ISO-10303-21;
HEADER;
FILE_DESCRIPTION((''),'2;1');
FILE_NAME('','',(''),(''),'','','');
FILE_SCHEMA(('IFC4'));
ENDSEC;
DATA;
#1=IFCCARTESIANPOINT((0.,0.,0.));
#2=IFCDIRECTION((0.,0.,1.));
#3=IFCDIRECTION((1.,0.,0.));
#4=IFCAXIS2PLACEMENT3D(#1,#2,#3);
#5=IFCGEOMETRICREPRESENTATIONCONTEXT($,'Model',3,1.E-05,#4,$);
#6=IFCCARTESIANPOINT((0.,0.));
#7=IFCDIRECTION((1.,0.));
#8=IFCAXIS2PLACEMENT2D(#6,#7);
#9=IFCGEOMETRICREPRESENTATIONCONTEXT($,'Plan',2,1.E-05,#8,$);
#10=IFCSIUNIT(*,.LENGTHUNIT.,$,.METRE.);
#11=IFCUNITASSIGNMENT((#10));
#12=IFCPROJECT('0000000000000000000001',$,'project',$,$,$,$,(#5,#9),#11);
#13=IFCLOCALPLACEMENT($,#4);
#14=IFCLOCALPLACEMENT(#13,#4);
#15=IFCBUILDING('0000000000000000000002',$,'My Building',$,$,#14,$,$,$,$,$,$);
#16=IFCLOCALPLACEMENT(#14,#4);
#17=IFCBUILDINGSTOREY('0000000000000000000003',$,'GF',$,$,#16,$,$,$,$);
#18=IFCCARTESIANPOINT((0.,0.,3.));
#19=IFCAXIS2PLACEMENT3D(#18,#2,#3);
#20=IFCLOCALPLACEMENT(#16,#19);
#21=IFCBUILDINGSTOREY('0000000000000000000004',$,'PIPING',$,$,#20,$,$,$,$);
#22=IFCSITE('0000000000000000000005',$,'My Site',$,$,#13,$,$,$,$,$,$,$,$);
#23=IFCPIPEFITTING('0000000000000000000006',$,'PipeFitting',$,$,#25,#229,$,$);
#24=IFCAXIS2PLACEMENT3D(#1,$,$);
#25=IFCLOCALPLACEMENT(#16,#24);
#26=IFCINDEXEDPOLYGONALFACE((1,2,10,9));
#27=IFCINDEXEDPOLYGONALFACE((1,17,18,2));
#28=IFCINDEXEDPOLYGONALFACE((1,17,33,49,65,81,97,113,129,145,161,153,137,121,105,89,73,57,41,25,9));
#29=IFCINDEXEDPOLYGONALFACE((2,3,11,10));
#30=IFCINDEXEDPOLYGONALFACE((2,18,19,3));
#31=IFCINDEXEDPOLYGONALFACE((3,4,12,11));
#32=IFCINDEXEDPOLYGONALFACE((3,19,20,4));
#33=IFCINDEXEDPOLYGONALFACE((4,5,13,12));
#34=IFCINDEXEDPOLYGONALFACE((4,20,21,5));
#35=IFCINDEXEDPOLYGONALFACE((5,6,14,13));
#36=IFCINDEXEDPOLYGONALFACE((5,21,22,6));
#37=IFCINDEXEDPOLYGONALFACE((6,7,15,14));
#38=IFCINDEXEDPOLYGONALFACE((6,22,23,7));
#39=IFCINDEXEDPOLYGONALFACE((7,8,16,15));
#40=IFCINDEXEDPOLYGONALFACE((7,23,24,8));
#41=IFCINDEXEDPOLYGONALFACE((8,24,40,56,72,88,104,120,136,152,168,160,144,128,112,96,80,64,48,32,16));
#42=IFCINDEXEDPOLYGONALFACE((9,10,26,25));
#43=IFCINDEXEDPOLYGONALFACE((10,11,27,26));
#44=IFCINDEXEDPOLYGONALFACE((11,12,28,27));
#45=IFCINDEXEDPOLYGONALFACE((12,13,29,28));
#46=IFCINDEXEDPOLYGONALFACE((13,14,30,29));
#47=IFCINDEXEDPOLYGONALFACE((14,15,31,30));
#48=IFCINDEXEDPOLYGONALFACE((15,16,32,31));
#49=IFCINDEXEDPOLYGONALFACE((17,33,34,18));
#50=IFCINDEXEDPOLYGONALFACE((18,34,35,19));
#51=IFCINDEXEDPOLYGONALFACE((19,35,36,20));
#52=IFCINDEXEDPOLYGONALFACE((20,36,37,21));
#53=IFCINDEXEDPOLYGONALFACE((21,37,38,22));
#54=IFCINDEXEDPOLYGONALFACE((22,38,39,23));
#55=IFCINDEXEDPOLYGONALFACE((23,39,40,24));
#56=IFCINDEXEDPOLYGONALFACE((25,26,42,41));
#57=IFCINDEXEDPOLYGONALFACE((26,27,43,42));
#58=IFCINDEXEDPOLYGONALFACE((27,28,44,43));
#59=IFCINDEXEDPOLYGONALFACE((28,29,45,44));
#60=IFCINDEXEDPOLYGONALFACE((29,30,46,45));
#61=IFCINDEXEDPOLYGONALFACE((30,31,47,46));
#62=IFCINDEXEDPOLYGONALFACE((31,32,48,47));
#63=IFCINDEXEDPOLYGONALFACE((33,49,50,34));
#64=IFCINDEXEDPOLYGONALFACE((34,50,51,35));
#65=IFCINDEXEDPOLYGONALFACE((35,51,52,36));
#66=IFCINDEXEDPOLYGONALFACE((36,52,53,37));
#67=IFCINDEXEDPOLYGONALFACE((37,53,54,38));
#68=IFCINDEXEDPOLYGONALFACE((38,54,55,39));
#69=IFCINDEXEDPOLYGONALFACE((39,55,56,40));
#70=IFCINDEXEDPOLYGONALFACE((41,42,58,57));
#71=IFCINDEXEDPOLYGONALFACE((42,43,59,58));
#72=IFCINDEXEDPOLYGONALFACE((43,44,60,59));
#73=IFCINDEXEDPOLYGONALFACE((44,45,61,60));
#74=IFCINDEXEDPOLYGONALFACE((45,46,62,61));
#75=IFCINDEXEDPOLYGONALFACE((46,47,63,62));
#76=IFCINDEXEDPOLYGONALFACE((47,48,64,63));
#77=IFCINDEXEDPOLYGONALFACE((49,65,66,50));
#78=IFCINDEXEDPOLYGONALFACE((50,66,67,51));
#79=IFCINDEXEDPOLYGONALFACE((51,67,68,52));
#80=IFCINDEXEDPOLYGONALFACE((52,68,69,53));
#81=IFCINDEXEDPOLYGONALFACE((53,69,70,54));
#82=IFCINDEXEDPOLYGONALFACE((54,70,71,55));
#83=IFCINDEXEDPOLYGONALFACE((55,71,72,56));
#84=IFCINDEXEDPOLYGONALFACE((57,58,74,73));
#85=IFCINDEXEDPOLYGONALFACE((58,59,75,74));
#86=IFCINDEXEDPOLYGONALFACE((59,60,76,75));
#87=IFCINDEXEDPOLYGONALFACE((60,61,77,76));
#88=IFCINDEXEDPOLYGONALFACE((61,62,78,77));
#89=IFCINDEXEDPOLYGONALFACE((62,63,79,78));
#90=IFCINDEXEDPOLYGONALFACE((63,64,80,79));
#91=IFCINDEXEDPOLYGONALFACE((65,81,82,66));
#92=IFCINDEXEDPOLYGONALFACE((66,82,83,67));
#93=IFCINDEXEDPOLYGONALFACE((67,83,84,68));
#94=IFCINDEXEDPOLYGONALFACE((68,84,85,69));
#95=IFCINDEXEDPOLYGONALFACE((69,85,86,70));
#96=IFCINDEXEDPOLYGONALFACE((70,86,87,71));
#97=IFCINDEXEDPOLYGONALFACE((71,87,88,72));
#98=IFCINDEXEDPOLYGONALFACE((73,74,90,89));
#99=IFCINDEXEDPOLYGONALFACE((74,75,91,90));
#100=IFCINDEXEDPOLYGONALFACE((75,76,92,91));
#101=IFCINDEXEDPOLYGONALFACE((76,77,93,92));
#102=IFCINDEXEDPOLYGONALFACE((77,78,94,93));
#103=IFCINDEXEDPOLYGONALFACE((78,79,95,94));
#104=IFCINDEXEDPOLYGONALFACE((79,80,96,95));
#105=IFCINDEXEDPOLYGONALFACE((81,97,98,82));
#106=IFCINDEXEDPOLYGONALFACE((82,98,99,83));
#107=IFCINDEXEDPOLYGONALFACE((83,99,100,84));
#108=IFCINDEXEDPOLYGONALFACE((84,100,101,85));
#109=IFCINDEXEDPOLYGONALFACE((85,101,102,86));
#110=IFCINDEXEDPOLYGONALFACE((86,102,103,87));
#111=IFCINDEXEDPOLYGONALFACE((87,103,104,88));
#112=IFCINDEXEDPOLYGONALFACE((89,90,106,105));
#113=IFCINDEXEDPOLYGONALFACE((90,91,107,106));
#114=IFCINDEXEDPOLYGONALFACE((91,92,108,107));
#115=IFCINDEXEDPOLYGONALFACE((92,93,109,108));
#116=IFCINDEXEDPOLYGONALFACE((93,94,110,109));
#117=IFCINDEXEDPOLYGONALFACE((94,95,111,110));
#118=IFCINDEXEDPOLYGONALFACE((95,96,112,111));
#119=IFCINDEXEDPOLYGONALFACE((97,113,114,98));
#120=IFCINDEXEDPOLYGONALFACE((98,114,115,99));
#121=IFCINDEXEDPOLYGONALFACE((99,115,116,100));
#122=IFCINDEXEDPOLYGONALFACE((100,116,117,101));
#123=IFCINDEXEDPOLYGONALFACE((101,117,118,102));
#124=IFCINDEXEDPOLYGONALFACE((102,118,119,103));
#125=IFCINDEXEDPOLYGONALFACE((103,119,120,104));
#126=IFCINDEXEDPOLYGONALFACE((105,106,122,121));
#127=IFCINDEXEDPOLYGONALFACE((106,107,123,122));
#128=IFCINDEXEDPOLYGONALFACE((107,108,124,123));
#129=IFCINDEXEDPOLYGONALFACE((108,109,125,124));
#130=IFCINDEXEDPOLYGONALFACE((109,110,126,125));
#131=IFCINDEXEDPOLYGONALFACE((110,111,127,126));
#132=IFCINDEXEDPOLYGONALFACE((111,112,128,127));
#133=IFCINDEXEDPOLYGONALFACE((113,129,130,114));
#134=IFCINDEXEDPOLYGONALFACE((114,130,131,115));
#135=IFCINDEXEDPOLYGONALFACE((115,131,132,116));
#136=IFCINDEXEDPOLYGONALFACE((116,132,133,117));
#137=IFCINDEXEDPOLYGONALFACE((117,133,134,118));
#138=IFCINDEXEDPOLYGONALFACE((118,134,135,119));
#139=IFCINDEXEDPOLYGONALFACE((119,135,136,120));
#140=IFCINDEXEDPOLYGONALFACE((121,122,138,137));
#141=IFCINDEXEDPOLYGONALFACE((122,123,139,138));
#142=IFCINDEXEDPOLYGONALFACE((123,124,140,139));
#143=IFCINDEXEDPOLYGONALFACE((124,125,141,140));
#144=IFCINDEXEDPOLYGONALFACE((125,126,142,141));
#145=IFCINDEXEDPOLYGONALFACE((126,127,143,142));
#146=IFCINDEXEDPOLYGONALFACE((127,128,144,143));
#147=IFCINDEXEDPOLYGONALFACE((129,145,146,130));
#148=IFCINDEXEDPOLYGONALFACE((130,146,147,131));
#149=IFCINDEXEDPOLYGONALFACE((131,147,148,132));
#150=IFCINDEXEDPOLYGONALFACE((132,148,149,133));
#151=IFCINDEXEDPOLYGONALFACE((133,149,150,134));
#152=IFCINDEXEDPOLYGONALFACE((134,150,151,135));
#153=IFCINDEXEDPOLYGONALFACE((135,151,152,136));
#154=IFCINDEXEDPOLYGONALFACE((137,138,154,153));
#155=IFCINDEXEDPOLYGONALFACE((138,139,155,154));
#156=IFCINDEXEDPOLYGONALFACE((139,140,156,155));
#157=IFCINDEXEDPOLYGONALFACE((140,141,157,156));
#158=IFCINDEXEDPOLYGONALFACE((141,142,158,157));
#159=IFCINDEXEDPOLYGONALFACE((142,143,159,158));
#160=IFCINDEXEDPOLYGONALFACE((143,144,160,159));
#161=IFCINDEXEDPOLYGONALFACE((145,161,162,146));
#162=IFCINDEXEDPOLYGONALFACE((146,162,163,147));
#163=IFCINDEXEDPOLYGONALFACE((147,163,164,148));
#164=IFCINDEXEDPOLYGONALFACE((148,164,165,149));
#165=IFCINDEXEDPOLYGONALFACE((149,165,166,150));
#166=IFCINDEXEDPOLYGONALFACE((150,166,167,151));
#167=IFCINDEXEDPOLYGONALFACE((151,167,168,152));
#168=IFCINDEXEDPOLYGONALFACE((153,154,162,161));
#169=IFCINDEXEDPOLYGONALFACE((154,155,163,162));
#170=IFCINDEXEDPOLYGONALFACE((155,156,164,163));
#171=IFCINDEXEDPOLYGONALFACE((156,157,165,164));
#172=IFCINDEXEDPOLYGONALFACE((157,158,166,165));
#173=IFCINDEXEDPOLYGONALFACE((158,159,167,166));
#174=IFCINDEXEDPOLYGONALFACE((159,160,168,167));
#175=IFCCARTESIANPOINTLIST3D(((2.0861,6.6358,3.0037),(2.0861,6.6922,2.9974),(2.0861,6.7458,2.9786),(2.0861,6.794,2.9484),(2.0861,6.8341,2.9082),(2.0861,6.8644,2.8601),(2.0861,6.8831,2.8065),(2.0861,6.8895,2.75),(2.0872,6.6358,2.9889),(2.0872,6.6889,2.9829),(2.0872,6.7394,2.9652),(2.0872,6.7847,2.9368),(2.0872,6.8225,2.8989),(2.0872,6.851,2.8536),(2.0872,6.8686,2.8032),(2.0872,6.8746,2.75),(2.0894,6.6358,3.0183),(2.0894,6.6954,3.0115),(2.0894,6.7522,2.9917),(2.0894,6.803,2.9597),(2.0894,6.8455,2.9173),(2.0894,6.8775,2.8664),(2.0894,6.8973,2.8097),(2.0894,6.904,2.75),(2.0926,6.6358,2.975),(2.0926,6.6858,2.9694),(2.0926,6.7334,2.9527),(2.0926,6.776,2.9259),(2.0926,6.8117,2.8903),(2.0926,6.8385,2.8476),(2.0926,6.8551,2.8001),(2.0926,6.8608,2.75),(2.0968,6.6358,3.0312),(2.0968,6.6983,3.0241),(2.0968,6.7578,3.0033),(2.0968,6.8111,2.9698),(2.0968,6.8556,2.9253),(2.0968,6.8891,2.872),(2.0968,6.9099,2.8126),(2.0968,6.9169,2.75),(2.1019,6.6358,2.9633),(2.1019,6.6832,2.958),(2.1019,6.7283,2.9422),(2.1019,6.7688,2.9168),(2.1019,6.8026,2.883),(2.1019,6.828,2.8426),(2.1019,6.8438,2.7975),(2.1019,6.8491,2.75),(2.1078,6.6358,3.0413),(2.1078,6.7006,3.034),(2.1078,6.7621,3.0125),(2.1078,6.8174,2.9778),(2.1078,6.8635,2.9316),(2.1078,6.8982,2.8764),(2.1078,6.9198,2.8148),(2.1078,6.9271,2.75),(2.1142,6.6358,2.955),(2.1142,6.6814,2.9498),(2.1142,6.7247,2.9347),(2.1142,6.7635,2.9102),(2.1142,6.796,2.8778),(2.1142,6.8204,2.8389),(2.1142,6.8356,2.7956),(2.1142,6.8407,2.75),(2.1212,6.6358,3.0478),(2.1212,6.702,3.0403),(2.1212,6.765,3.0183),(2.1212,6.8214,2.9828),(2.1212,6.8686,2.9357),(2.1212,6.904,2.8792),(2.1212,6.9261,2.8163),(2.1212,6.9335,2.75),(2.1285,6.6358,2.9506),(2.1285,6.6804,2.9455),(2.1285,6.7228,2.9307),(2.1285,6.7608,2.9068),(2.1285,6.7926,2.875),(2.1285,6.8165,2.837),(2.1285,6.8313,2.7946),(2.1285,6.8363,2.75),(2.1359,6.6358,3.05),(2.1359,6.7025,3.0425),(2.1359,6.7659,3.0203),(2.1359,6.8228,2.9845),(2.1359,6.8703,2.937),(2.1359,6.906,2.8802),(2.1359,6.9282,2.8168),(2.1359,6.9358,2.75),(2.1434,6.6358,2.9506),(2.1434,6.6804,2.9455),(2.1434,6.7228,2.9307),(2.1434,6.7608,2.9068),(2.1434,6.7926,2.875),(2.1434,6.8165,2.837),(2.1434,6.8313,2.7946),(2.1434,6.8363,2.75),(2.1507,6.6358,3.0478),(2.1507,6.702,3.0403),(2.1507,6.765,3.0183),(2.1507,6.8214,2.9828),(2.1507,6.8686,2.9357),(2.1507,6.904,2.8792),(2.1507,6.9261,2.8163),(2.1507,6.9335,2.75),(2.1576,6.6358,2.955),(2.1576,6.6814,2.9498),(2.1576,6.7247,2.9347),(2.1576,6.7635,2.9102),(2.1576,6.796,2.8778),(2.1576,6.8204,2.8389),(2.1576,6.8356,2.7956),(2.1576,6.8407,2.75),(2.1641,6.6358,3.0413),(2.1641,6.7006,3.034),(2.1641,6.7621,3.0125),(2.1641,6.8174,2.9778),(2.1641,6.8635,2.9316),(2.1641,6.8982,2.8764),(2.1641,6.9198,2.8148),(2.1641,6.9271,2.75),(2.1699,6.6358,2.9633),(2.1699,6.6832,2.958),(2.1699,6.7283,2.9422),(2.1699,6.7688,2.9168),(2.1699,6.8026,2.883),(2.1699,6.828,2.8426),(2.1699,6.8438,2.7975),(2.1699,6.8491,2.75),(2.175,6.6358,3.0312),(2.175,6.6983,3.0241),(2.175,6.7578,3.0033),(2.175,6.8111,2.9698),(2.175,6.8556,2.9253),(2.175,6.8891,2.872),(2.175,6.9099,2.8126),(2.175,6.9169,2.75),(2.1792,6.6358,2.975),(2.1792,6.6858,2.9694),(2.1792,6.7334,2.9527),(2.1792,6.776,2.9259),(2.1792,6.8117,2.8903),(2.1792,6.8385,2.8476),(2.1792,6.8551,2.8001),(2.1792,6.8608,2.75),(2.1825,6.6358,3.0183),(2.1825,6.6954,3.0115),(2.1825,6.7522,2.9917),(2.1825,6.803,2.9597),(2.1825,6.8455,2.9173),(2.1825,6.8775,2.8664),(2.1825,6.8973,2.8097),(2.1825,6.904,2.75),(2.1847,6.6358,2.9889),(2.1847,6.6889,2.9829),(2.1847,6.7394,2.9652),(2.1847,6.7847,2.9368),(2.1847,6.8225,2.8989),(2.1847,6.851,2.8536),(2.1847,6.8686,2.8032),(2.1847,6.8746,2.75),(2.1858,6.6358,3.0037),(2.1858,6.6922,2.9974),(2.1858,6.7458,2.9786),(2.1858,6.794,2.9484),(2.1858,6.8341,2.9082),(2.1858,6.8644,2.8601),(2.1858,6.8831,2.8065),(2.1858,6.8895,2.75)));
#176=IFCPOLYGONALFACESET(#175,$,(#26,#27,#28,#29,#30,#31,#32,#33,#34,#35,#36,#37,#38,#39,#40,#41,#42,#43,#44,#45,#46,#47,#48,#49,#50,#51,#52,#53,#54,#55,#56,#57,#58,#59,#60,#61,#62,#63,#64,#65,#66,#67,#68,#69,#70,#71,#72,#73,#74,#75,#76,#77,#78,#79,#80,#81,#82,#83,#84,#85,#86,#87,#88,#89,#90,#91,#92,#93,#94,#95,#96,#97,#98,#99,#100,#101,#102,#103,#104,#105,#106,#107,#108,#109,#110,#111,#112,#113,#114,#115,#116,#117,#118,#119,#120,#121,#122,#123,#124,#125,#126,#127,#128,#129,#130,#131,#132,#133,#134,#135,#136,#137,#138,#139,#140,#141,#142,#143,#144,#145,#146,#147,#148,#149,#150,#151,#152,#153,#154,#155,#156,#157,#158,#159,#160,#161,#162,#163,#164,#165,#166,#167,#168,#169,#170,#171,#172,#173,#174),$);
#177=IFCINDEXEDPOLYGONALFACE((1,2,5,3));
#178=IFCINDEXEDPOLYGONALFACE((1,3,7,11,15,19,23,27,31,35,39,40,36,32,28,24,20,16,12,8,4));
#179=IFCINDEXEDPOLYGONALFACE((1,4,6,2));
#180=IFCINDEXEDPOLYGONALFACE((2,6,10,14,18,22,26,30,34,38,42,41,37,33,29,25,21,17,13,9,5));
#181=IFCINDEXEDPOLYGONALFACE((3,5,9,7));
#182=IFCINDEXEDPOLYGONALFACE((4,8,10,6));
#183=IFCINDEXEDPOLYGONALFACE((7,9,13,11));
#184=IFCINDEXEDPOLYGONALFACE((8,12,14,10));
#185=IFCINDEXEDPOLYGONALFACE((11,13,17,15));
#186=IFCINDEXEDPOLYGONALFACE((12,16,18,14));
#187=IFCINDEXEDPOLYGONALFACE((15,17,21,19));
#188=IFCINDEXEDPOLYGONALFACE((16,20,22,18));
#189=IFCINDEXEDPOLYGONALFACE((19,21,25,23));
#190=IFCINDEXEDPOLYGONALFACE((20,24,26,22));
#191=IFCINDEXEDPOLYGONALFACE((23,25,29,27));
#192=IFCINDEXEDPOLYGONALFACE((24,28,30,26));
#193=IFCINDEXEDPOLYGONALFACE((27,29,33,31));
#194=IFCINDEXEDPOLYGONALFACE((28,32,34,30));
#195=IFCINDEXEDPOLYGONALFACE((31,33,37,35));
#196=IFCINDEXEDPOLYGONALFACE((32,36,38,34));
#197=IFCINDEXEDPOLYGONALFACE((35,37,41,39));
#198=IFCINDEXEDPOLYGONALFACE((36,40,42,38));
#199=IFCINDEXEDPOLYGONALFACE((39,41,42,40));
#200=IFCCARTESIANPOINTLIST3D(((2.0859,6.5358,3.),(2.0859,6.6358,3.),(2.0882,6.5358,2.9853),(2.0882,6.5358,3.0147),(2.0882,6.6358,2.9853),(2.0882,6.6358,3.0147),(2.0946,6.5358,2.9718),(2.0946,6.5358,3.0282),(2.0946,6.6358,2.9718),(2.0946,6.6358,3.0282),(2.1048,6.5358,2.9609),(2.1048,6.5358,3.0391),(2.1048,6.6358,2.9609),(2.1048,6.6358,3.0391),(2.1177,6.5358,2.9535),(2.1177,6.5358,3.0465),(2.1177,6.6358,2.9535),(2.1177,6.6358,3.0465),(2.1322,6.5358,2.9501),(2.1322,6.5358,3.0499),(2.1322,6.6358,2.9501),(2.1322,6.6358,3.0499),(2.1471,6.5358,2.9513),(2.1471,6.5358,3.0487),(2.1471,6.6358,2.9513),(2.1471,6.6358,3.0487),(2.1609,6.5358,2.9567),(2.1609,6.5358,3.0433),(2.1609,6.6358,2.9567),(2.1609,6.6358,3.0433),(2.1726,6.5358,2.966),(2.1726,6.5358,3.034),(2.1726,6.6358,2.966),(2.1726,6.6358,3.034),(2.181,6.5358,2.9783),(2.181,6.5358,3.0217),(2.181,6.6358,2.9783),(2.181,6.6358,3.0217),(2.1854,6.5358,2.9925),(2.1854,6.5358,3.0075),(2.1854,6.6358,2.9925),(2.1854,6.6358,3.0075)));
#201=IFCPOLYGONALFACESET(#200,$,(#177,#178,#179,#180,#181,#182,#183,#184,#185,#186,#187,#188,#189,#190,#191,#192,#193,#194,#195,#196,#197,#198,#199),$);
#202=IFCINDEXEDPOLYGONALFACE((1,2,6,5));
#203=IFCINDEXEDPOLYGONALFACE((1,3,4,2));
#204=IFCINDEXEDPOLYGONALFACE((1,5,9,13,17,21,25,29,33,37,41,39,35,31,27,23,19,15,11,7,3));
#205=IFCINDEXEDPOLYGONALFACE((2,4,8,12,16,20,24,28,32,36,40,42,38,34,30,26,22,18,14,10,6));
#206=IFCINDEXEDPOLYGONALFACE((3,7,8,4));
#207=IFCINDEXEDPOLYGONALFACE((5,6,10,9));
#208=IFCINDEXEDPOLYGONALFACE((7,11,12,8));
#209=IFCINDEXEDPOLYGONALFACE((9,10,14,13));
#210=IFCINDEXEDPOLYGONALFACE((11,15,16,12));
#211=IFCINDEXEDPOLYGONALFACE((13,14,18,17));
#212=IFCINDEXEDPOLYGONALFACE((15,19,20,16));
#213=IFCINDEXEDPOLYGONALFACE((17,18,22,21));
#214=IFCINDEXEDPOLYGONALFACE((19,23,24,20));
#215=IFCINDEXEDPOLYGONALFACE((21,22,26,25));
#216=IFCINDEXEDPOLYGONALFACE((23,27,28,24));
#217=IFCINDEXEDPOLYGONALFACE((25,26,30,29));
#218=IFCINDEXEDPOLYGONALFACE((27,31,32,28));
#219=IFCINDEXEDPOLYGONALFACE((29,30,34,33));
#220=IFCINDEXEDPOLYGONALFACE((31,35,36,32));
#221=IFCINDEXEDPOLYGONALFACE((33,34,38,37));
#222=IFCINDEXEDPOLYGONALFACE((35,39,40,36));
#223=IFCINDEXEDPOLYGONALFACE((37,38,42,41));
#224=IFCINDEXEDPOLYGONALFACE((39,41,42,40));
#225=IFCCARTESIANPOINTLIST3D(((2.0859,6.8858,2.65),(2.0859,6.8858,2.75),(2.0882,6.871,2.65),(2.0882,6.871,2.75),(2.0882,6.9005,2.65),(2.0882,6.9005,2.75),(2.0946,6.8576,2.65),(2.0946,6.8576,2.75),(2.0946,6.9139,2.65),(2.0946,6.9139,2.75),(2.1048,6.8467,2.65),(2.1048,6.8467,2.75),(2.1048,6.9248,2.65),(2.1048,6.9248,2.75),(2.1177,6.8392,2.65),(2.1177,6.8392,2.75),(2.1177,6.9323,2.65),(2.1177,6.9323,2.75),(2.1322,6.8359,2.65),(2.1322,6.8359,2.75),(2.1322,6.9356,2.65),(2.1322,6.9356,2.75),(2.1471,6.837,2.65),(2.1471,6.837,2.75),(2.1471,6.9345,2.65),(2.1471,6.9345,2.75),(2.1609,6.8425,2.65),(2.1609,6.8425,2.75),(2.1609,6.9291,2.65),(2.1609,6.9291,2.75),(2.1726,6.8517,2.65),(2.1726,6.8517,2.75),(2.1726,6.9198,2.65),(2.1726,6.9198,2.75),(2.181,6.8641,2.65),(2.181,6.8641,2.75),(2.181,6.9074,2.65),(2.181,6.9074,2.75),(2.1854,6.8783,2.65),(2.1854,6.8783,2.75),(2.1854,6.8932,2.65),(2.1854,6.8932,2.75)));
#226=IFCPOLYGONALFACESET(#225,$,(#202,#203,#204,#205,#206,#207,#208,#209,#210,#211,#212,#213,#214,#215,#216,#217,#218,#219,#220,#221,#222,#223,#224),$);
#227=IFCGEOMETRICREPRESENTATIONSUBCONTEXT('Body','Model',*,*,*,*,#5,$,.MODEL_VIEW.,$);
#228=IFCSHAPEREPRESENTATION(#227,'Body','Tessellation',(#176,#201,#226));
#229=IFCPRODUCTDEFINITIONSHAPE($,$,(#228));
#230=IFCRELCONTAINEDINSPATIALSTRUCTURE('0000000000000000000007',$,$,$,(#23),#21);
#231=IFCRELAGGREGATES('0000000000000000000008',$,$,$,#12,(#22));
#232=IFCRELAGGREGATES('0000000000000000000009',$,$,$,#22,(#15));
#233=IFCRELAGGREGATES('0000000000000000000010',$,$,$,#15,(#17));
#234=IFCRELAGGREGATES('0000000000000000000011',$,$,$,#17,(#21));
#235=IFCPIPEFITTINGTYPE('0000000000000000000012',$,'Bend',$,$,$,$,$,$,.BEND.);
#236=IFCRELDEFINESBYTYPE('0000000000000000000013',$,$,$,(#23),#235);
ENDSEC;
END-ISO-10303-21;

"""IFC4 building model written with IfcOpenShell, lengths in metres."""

from ifc_helpers import new_model, entity, si_unit, frame, origin_with_axes, origin_2d_with_axis, place, context, subcontext, project, spatial, circle, extrude, source, transform, mapped, type_object, type_shapes, element, save


model = new_model("IFC4")

# Units and contexts
model_context = context("Model", 3, precision=1e-05, world=origin_with_axes())
plan_context = context("Plan", 2, precision=1e-05, world=origin_2d_with_axis())
body_context = subcontext(model_context, "Body", "Model", "MODEL_VIEW")
ifc_project = project(units=[si_unit("LENGTHUNIT", "METRE")], contexts=[model_context, plan_context])

# Site, building, storeys
site_placement = place(None, origin_with_axes())
site = spatial("IfcSite", under=ifc_project, at=site_placement, Name="My Site")
building_placement = place(site_placement, origin_with_axes())
building = spatial("IfcBuilding", under=site, at=building_placement, Name="My Building")
storey_1_placement = place(building_placement, origin_with_axes())
storey_1 = spatial("IfcBuildingStorey", under=building, at=storey_1_placement, Name="GF")
storey_2_placement = place(storey_1_placement, frame((0.0, 0.0, 3.0), z_axis=(0.0, 0.0, 1.0), x_axis=(1.0, 0.0, 0.0)))
storey_2 = spatial("IfcBuildingStorey", under=storey_1, at=storey_2_placement, Name="PIPING")

# Pipe fitting
pipe_fitting_type = type_object("IfcPipeFittingType", Name="Bend", PredefinedType="BEND")
shared_shape = source(origin_with_axes(), body_context, "Body", "SolidModel", [
    entity("IfcSweptDiskSolid", entity("IfcIndexedPolyCurve", entity("IfcCartesianPointList3D", [[0.0, 0.0, -0.1], [0.0, 0.0732, -0.2768], [0.0, 0.25, -0.35]]), [entity("IfcArcIndex", [1, 2, 3])]), 0.05),
    extrude(circle(Radius=0.05), origin_with_axes(), (0.0, 0.0, -1.0), 0.1),
    extrude(circle(Radius=0.05), frame((0.0, 0.25, -0.35), z_axis=(0.0, 1.0, 0.0), x_axis=(1.0, 0.0, 0.0)), (0.0, 0.0, 1.0), 0.1),
])
type_shapes(pipe_fitting_type, [shared_shape])
for number, where, z_axis, x_axis, name in (
    (1, (2.1359, 6.5358, 0.0), (0.0, -1.0, 0.0), (-1.0, 0.0, 0.0), "PipeFitting"),
):
    element("IfcPipeFitting", number, at=place(storey_2_placement, frame(where, z_axis=z_axis, x_axis=x_axis)), inside=storey_2, type_object=pipe_fitting_type, Name=name, context=body_context, shape_type="MappedRepresentation", body=[
        mapped(shared_shape, transform((0.0, 0.0, 0.0), x_axis=(1.0, 0.0, 0.0), y_axis=(0.0, 1.0, 0.0), z_axis=(0.0, 0.0, 1.0), scale=1.0)),
    ])

save(model, "model.ifc")
